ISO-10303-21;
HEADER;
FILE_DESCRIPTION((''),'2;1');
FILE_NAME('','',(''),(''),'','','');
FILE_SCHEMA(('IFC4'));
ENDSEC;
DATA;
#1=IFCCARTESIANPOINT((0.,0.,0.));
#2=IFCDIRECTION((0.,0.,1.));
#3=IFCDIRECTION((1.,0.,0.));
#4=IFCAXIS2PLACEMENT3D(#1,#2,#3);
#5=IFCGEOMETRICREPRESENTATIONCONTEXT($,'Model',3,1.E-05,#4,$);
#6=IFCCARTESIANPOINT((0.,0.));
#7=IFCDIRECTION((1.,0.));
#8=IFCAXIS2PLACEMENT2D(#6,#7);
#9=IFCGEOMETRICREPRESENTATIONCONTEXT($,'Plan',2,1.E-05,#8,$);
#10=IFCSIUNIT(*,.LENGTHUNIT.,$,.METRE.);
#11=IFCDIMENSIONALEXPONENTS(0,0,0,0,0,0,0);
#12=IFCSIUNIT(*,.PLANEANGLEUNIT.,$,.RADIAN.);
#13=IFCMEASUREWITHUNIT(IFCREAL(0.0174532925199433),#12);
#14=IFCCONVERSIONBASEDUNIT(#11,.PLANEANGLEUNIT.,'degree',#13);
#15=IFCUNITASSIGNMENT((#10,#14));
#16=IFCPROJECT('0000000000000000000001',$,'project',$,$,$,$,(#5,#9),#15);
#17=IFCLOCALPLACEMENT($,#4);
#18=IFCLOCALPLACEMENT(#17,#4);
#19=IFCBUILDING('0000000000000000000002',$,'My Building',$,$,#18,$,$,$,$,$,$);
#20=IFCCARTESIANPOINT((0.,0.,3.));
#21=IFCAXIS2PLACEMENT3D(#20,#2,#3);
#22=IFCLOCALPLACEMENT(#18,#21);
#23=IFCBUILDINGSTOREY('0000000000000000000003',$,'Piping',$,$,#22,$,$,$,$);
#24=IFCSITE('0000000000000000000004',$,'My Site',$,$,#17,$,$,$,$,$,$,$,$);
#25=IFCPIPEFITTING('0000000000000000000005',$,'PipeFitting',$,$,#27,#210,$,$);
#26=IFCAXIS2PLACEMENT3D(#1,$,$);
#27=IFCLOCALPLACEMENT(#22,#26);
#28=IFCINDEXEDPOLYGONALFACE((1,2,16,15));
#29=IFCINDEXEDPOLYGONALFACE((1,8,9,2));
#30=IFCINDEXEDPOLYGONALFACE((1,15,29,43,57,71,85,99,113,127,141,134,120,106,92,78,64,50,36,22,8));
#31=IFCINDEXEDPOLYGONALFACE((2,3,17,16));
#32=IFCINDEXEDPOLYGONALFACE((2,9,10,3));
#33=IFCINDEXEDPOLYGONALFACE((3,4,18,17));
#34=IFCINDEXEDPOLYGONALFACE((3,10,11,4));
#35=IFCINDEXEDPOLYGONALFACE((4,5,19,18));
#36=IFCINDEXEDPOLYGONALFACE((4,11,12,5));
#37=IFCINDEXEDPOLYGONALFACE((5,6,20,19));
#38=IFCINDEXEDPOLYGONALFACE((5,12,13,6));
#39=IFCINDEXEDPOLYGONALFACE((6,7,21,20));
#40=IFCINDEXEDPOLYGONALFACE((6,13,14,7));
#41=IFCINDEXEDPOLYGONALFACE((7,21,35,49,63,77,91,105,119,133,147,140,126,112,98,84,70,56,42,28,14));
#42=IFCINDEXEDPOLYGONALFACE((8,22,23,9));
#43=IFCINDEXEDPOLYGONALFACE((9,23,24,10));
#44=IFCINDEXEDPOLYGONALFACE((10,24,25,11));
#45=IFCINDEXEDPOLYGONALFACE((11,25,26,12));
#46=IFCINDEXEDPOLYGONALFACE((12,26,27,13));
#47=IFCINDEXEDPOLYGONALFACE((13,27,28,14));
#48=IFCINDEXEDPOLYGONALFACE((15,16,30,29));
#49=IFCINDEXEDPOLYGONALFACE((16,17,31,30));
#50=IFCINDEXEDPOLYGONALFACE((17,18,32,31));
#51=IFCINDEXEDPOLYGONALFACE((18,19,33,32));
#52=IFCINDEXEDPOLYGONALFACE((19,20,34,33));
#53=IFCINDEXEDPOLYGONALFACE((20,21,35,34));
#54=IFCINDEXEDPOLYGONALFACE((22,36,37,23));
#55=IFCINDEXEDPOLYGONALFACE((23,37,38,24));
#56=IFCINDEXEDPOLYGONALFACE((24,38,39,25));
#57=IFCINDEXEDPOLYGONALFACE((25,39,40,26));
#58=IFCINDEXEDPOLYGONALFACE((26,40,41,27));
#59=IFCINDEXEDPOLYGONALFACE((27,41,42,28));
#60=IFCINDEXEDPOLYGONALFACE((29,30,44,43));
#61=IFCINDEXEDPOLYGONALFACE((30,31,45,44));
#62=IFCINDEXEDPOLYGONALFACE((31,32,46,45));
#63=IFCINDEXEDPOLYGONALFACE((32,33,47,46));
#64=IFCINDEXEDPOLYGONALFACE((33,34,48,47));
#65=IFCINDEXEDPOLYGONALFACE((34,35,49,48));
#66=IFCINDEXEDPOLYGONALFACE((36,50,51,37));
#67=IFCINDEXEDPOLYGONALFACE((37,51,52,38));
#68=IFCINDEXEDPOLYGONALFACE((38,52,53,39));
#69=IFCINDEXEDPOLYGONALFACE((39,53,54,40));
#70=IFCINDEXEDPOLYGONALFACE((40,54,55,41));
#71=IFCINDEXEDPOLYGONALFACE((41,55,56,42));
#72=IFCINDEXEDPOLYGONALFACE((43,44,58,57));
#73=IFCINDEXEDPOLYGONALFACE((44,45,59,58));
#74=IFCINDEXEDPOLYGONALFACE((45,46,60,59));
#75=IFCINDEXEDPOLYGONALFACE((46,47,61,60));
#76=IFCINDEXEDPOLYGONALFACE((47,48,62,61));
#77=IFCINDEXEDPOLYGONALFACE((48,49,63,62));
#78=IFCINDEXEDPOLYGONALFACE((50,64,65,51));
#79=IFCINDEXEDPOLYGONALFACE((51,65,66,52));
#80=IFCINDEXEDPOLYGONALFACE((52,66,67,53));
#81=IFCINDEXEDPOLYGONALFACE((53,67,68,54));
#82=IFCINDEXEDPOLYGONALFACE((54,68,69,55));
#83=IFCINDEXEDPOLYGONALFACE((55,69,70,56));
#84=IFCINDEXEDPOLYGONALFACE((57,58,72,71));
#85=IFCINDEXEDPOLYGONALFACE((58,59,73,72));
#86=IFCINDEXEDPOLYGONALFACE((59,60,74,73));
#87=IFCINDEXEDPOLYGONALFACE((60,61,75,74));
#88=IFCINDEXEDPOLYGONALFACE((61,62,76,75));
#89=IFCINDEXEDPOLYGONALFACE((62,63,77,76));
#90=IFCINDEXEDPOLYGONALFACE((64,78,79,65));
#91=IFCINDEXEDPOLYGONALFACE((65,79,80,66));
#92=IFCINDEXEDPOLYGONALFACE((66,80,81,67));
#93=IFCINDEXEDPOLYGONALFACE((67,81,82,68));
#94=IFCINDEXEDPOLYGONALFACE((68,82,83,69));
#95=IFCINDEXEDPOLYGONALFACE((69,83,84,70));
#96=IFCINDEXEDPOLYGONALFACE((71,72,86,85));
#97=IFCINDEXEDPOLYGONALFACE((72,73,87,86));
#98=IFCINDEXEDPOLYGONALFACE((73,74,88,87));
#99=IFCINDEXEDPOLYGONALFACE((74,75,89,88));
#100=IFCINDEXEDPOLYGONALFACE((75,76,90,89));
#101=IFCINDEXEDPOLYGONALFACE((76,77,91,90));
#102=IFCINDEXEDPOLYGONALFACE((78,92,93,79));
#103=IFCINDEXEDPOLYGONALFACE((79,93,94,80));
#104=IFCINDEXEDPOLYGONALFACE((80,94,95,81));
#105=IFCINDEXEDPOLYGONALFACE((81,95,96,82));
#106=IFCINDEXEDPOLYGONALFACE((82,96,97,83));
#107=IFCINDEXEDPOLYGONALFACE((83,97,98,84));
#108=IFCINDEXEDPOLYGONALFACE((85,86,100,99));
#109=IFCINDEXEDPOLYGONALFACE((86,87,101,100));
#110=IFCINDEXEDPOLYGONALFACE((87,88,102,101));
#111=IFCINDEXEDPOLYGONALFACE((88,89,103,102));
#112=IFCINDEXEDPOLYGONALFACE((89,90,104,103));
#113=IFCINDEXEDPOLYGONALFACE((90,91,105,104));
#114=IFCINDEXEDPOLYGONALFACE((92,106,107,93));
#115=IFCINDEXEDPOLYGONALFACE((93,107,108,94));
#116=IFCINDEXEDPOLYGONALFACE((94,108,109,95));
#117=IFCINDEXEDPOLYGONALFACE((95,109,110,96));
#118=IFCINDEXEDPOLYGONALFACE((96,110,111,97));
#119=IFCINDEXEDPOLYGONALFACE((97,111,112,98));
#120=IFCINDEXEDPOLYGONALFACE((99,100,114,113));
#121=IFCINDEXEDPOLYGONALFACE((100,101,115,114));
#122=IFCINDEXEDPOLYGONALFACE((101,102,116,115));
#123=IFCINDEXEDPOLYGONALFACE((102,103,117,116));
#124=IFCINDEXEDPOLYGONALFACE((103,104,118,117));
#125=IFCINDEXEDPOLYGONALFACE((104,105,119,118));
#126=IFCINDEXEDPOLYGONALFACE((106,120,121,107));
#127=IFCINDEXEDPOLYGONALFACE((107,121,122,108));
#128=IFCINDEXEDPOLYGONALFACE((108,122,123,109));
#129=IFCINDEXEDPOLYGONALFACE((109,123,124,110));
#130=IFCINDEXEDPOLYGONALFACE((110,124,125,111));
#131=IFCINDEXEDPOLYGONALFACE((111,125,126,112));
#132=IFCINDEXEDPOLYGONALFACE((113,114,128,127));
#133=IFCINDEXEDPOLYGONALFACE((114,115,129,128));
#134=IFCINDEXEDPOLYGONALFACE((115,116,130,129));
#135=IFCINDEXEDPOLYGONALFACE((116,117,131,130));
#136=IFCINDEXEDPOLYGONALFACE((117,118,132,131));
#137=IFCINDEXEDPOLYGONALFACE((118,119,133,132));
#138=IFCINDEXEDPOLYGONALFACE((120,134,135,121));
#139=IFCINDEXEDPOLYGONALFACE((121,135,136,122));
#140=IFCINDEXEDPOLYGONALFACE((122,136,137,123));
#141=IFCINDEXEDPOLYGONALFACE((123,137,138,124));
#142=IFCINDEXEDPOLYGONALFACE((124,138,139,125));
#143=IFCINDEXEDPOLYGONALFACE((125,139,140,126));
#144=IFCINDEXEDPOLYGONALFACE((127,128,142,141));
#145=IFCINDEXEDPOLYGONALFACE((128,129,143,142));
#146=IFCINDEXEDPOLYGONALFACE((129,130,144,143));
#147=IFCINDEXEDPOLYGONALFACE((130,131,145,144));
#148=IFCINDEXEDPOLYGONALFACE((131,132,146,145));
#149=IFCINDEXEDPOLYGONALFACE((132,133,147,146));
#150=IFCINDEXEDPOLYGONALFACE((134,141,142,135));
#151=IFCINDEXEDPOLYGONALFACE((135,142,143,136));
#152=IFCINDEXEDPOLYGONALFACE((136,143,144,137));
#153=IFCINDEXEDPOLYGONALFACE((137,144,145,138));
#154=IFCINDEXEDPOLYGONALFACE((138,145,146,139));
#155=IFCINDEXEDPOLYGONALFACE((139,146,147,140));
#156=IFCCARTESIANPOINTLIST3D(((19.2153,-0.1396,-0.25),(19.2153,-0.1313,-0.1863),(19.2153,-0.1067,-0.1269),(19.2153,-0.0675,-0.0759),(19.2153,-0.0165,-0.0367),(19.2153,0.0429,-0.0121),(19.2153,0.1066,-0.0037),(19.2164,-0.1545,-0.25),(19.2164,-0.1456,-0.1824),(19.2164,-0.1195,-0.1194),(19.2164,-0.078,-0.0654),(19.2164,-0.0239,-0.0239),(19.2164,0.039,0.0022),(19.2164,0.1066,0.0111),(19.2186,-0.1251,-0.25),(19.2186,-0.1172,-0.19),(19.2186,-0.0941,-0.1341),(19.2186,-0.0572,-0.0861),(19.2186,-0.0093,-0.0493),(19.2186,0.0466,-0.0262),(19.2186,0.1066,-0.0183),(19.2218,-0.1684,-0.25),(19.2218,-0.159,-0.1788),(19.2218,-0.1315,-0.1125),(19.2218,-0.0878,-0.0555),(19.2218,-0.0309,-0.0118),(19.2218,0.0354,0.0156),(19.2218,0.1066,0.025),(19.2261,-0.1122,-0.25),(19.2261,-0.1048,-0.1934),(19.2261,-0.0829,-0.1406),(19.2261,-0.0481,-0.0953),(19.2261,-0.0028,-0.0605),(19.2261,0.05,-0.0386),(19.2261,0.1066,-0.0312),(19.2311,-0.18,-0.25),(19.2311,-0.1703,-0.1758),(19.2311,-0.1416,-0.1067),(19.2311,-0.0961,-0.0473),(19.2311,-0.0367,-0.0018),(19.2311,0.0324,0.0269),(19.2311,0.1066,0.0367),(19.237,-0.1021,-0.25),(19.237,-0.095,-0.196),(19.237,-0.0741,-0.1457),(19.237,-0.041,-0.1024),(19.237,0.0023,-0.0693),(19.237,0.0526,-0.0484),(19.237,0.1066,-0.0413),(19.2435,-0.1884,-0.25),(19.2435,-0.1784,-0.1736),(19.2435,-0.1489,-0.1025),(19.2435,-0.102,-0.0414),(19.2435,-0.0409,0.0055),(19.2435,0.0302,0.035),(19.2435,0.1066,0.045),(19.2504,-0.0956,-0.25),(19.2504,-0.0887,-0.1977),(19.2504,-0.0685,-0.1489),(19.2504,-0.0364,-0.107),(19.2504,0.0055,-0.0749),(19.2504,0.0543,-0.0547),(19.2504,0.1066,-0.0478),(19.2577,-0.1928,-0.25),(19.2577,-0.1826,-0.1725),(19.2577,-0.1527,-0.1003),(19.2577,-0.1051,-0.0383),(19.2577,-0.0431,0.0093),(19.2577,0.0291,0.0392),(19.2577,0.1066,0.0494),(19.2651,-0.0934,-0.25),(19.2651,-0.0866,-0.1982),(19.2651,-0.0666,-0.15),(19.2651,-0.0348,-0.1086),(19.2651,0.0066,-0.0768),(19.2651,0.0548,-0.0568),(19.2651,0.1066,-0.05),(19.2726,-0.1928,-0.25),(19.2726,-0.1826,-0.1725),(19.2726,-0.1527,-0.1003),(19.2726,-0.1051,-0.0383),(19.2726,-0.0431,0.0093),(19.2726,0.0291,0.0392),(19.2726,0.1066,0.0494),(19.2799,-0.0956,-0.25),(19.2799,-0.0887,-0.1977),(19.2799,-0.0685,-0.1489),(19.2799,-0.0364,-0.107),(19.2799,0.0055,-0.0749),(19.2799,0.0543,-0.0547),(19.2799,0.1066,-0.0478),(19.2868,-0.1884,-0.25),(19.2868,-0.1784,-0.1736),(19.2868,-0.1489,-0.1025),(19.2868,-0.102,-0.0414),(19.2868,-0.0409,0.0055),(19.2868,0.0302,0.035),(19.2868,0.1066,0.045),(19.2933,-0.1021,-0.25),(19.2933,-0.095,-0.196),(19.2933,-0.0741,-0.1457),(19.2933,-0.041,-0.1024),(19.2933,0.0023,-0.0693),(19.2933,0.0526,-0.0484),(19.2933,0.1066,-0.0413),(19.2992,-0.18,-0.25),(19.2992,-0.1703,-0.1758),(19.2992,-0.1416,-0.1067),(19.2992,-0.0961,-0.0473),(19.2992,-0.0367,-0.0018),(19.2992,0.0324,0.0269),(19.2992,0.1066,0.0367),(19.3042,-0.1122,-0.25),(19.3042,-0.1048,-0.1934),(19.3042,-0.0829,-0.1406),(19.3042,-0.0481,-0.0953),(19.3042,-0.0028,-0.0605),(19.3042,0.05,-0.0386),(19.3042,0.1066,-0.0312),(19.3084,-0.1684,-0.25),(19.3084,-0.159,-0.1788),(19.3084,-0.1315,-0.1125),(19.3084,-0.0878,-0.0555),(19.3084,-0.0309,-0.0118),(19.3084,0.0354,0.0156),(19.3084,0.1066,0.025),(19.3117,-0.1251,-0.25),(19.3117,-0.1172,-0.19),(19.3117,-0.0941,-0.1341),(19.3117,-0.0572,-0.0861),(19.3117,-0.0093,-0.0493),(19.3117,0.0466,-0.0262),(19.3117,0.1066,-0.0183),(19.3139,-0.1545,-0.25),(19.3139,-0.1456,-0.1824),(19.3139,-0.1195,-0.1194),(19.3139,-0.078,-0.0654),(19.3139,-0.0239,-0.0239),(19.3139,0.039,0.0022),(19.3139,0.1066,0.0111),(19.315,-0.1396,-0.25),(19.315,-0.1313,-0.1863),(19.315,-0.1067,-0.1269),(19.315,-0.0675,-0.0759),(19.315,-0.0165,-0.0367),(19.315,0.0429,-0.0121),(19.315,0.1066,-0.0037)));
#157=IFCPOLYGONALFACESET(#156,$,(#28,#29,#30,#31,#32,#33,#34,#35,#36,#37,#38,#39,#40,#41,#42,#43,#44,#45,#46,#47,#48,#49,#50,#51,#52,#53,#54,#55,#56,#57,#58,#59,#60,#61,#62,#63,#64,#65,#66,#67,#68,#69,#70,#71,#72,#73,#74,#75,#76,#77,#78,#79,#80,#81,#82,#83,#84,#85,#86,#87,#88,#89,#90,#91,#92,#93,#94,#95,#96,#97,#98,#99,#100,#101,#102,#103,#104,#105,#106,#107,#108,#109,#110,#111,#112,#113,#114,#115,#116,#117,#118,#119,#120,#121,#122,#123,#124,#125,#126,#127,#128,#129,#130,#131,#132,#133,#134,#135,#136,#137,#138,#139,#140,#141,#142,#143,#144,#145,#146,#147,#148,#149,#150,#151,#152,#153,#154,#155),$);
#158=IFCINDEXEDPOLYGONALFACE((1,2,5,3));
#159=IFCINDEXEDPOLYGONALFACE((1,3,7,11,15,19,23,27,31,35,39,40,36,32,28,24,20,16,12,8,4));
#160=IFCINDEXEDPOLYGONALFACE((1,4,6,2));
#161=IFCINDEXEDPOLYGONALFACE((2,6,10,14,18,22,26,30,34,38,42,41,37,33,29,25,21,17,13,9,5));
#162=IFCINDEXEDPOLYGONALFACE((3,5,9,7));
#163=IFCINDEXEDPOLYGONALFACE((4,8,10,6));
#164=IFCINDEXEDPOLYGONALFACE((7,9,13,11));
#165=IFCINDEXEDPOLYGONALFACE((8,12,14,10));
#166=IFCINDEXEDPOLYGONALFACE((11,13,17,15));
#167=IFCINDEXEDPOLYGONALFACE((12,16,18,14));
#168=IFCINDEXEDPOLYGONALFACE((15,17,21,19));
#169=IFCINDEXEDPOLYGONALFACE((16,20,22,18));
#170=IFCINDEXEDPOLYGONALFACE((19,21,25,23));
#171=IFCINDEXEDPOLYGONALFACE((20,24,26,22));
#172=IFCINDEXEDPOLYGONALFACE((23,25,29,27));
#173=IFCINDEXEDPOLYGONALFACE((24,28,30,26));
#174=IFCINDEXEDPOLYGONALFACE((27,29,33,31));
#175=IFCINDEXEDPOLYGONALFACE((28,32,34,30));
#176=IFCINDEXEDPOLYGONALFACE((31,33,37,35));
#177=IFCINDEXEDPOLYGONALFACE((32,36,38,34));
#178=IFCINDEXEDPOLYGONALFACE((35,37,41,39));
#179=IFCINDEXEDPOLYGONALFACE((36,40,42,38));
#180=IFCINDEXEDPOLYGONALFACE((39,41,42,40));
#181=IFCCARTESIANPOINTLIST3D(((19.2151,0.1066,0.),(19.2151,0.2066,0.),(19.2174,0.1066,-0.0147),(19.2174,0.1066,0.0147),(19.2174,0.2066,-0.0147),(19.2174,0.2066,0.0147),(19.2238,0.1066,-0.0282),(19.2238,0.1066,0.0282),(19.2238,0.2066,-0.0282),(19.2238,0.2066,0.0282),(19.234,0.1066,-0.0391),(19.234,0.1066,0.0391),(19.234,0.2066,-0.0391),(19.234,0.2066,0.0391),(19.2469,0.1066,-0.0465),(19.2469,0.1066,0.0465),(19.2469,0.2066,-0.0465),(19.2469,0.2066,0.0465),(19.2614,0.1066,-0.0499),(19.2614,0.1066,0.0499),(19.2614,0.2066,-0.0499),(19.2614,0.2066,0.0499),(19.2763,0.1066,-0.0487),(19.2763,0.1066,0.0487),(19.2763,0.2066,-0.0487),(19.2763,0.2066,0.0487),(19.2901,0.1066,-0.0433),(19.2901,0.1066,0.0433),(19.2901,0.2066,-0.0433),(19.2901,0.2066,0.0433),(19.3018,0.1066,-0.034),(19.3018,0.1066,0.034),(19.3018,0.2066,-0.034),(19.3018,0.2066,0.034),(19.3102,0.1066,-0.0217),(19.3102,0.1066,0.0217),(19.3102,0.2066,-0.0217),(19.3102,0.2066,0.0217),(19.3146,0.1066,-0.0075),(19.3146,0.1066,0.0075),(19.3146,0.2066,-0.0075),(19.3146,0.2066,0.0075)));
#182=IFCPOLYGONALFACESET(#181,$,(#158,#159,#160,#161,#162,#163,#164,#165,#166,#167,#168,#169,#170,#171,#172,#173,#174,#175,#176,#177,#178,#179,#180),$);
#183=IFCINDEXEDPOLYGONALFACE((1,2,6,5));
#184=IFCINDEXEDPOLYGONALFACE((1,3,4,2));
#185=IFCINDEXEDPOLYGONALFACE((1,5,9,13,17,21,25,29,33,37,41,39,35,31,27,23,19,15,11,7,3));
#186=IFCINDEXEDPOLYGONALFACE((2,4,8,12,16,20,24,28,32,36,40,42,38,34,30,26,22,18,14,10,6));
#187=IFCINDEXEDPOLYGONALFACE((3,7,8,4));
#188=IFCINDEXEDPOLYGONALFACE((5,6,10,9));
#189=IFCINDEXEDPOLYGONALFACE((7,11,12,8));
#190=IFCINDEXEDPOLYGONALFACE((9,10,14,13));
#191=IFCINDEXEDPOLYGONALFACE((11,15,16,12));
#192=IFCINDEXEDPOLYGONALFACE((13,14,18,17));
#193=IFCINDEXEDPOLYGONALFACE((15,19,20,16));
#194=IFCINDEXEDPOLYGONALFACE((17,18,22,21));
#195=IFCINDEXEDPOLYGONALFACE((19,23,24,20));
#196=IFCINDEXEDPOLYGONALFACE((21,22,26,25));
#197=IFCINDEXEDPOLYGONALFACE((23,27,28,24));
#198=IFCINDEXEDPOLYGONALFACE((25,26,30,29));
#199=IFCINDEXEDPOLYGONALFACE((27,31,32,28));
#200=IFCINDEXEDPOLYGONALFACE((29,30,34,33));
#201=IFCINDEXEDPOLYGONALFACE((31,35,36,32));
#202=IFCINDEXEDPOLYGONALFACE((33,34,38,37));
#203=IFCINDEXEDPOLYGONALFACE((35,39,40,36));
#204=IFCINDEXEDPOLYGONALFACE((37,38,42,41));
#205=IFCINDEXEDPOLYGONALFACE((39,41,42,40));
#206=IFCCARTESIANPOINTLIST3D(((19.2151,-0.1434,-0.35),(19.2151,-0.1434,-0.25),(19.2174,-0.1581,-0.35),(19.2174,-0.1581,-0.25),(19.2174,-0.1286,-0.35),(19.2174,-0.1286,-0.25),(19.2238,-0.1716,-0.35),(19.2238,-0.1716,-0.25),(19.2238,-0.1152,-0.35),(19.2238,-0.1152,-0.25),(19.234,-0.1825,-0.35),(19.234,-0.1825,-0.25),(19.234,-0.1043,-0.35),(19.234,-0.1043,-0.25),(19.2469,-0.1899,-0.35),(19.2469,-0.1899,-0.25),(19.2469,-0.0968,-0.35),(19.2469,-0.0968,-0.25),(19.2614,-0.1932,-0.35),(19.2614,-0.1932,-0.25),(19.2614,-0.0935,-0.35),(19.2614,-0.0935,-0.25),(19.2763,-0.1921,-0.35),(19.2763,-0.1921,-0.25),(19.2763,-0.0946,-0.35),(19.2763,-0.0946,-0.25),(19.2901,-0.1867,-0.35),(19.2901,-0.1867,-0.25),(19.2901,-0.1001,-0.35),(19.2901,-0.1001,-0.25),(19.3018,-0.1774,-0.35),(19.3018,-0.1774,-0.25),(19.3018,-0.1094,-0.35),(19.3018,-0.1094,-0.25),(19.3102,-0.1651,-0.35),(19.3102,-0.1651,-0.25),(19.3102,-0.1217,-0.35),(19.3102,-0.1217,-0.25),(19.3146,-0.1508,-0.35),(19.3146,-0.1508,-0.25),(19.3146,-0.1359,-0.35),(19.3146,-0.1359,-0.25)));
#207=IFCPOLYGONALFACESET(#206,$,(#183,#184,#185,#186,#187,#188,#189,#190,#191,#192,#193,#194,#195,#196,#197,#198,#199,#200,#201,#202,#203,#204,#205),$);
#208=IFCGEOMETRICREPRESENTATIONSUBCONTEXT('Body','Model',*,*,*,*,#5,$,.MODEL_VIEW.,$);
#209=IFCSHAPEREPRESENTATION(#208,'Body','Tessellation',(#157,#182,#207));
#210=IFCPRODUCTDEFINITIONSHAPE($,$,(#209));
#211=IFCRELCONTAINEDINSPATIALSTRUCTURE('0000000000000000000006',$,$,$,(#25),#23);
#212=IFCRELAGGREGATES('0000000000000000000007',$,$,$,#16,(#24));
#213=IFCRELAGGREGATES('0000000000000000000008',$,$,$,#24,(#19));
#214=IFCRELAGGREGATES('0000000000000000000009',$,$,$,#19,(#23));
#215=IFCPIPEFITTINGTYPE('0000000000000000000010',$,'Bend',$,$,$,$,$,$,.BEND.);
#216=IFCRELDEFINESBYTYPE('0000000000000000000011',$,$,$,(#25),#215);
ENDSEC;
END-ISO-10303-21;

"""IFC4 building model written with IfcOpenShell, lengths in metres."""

from ifc_helpers import new_model, entity, si_unit, converted_unit, frame, origin_with_axes, origin_2d_with_axis, place, context, subcontext, project, spatial, circle, extrude, source, transform, mapped, type_object, type_shapes, element, save


model = new_model("IFC4")

# Units and contexts
model_context = context("Model", 3, precision=1e-05, world=origin_with_axes())
plan_context = context("Plan", 2, precision=1e-05, world=origin_2d_with_axis())
body_context = subcontext(model_context, "Body", "Model", "MODEL_VIEW")
ifc_project = project(units=[si_unit("LENGTHUNIT", "METRE"), converted_unit("PLANEANGLEUNIT", "degree", entity("IfcReal", 0.0174532925199433), si_unit("PLANEANGLEUNIT", "RADIAN"), dimensions=[0, 0, 0, 0, 0, 0, 0])], contexts=[model_context, plan_context])

# Site, building, storey
site_placement = place(None, origin_with_axes())
site = spatial("IfcSite", under=ifc_project, at=site_placement, Name="My Site")
building_placement = place(site_placement, origin_with_axes())
building = spatial("IfcBuilding", under=site, at=building_placement, Name="My Building")
storey_placement = place(building_placement, frame((0.0, 0.0, 3.0), z_axis=(0.0, 0.0, 1.0), x_axis=(1.0, 0.0, 0.0)))
storey = spatial("IfcBuildingStorey", under=building, at=storey_placement, Name="Piping")

# Pipe fitting
pipe_fitting_type = type_object("IfcPipeFittingType", Name="Bend", PredefinedType="BEND")
shared_shape = source(origin_with_axes(), body_context, "Body", "SolidModel", [
    entity("IfcSweptDiskSolid", entity("IfcIndexedPolyCurve", entity("IfcCartesianPointList3D", [[0.0, 0.0, -0.1], [0.0, -0.0732, -0.2768], [0.0, -0.25, -0.35]]), [entity("IfcArcIndex", [1, 2, 3])]), 0.05),
    extrude(circle(Radius=0.05), origin_with_axes(), (0.0, 0.0, -1.0), 0.1),
    extrude(circle(Radius=0.05), frame((0.0, -0.25, -0.35), z_axis=(0.0, -1.0, 0.0), x_axis=(1.0, 0.0, 0.0)), (0.0, 0.0, 1.0), 0.1),
])
type_shapes(pipe_fitting_type, [shared_shape])
for number, where, z_axis, x_axis, name in (
    (1, (19.2651, 0.2066, 0.0), (0.0, 1.0, 0.0), (-1.0, 0.0, 0.0), "PipeFitting"),
):
    element("IfcPipeFitting", number, at=place(storey_placement, frame(where, z_axis=z_axis, x_axis=x_axis)), inside=storey, type_object=pipe_fitting_type, Name=name, context=body_context, shape_type="MappedRepresentation", body=[
        mapped(shared_shape, transform((0.0, 0.0, 0.0), x_axis=(1.0, 0.0, 0.0), y_axis=(0.0, 1.0, 0.0), z_axis=(0.0, 0.0, 1.0), scale=1.0)),
    ])

save(model, "model.ifc")
